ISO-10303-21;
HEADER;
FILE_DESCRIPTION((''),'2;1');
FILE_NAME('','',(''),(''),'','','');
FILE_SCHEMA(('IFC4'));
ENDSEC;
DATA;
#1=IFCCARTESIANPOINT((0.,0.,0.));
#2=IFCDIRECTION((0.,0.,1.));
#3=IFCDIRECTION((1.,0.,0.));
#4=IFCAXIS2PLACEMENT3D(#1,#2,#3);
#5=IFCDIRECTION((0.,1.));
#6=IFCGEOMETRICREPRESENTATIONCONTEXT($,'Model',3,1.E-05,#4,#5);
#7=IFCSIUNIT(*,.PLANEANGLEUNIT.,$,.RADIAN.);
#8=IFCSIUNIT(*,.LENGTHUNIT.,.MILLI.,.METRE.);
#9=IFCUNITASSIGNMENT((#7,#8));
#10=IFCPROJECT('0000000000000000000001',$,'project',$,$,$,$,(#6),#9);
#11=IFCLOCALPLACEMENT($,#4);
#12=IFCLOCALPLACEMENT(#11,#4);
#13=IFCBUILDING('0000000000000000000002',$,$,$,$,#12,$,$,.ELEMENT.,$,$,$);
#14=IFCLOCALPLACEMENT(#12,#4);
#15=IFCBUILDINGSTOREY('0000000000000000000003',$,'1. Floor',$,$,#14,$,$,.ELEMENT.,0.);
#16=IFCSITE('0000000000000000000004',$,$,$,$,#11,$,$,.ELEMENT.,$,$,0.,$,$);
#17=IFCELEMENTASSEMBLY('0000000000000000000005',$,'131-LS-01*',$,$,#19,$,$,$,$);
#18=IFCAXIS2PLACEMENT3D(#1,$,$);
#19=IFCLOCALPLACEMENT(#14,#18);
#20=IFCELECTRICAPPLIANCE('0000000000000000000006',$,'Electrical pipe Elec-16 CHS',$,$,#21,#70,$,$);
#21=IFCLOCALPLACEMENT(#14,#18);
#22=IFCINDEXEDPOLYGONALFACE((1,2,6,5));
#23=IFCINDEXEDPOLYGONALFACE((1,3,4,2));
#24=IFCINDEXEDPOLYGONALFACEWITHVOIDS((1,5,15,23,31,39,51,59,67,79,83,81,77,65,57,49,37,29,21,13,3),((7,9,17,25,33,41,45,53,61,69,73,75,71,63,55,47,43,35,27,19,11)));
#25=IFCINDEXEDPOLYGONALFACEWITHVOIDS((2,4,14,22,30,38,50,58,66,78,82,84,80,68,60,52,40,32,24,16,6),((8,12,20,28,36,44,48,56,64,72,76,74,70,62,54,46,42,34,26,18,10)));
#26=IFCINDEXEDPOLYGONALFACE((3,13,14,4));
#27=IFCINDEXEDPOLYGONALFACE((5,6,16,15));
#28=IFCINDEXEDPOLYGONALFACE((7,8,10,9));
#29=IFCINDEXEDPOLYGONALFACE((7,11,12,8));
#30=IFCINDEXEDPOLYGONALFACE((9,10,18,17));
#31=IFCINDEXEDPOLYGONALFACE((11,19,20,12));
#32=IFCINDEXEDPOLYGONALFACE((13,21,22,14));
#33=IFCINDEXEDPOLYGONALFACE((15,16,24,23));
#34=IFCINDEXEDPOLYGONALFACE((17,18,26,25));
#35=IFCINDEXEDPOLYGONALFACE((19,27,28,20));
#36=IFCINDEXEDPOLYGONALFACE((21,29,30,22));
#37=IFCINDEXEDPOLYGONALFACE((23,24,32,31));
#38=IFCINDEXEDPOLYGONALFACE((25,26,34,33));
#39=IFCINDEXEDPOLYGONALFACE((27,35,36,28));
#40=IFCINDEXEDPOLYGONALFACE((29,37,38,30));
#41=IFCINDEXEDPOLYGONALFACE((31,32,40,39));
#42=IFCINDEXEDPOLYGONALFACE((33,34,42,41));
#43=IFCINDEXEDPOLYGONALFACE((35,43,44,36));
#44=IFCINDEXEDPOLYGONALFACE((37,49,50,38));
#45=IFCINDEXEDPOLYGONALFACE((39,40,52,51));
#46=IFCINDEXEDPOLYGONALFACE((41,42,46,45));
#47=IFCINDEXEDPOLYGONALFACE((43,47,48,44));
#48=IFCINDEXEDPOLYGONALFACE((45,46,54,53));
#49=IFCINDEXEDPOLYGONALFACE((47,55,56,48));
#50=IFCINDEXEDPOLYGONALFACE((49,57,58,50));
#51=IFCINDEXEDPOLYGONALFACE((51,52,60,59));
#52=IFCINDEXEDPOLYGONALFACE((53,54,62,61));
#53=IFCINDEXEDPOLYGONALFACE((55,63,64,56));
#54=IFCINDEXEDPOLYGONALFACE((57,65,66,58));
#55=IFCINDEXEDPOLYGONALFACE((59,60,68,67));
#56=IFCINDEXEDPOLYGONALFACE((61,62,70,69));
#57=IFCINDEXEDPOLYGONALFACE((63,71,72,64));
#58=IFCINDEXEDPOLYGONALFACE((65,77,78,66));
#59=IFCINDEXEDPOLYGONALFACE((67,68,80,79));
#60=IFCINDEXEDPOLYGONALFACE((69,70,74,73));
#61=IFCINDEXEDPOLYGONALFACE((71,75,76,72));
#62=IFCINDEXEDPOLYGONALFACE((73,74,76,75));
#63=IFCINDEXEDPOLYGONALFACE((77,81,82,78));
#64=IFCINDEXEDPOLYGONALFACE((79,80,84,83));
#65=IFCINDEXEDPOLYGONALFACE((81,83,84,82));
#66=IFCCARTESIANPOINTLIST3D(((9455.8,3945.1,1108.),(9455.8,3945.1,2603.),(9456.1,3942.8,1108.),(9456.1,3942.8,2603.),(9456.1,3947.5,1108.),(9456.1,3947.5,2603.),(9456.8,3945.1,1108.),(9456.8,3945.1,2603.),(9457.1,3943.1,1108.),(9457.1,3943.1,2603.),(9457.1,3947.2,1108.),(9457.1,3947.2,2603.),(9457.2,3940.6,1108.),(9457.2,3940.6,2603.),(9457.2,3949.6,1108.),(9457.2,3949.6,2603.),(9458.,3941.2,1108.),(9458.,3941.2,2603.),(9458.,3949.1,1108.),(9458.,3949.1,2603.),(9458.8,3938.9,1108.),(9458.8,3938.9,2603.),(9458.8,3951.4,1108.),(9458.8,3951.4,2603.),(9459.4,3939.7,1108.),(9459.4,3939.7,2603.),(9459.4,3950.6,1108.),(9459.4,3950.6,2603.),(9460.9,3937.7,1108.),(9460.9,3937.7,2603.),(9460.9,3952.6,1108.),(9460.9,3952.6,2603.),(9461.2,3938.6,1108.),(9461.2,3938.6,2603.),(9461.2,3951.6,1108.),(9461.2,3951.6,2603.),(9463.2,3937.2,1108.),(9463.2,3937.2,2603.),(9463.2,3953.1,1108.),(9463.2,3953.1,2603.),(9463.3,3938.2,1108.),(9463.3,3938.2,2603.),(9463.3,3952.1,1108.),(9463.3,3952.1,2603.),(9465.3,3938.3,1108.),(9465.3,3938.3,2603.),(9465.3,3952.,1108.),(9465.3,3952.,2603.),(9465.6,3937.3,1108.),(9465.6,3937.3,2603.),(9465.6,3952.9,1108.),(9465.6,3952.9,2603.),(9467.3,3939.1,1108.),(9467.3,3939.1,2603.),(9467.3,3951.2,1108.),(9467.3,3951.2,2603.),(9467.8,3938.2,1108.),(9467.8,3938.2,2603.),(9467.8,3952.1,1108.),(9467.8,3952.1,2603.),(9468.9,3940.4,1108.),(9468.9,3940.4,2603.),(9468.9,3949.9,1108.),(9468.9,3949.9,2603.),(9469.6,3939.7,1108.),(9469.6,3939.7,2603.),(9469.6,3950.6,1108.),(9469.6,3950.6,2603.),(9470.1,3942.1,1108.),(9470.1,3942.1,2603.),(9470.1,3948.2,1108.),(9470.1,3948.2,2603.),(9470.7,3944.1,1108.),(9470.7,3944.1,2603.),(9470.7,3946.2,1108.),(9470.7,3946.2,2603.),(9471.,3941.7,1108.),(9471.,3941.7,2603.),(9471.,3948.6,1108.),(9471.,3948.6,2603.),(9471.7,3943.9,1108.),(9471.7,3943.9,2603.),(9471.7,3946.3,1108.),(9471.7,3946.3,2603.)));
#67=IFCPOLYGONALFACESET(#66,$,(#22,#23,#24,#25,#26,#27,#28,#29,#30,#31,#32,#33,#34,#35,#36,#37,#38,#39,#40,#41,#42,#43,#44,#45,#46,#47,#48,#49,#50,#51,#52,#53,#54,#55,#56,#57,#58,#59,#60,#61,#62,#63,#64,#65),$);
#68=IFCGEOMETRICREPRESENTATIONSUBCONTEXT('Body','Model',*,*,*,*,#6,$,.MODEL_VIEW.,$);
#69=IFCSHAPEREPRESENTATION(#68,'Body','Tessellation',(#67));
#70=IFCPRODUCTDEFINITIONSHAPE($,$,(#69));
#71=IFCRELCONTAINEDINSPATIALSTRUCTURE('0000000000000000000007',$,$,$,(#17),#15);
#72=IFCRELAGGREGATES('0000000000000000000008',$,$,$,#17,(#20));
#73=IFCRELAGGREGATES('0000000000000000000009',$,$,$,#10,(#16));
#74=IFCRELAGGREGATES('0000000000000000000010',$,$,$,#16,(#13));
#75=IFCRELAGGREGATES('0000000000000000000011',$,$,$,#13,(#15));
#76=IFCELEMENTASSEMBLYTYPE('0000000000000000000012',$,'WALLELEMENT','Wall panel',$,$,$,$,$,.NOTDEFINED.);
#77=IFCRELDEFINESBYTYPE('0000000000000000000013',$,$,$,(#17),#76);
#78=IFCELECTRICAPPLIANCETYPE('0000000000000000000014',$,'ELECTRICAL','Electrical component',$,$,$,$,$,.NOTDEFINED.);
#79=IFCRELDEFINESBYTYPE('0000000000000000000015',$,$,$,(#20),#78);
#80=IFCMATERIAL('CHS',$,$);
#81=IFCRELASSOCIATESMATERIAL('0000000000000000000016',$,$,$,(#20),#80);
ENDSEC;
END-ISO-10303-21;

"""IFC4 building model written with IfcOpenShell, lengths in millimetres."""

from ifc_helpers import new_model, si_unit, direction, frame, origin_with_axes, origin_2d_with_axis, place, context, subcontext, project, spatial, hollow_circle, extrude, material, type_object, element, aggregate, save


model = new_model("IFC4")

# Units and contexts
model_context = context("Model", 3, precision=1e-05, world=origin_with_axes(), true_north=direction((0.0, 1.0)))
body_context = subcontext(model_context, "Body", "Model", "MODEL_VIEW")
ifc_project = project(units=[si_unit("PLANEANGLEUNIT", "RADIAN"), si_unit("LENGTHUNIT", "METRE", prefix="MILLI")], contexts=[model_context])

# Site, building, storey
site_placement = place(None, origin_with_axes())
site = spatial("IfcSite", under=ifc_project, at=site_placement, CompositionType="ELEMENT", RefElevation=0.0)
building_placement = place(site_placement, origin_with_axes())
building = spatial("IfcBuilding", under=site, at=building_placement, CompositionType="ELEMENT")
storey_placement = place(building_placement, origin_with_axes())
storey = spatial("IfcBuildingStorey", under=building, at=storey_placement, Name="1. Floor", CompositionType="ELEMENT", Elevation=0.0)

# Element assembly
element_assembly_type_1 = type_object("IfcElementAssemblyType", Name="WALLELEMENT", Description="Wall panel", PredefinedType="NOTDEFINED")
assembly_1_placement = place(storey_placement, origin_with_axes())
assembly_1 = element("IfcElementAssembly", 1, at=assembly_1_placement, inside=storey, type_object=element_assembly_type_1, Name="131-LS-01*")

# Electric appliance
ifc_material_1 = material(Name="CHS")
electric_appliance_type = type_object("IfcElectricApplianceType", Name="ELECTRICAL", Description="Electrical component", PredefinedType="NOTDEFINED")
electric_appliance_placement = place(storey_placement, frame((9463.8, 3945.1, 1108.0), z_axis=(0.0, 0.0, 1.0), x_axis=(-1.0, 0.0, 0.0)))
electric_appliance = element("IfcElectricAppliance", 2, at=electric_appliance_placement, type_object=electric_appliance_type, material=ifc_material_1, Name="Electrical pipe Elec-16 CHS", context=body_context, shape_type="SweptSolid", body=[
    extrude(hollow_circle(Radius=8.0, WallThickness=1.0, at=origin_2d_with_axis()), origin_with_axes(), (0.0, 0.0, 1.0), 1495.0),
])
aggregate(assembly_1, [electric_appliance])

save(model, "model.ifc")
